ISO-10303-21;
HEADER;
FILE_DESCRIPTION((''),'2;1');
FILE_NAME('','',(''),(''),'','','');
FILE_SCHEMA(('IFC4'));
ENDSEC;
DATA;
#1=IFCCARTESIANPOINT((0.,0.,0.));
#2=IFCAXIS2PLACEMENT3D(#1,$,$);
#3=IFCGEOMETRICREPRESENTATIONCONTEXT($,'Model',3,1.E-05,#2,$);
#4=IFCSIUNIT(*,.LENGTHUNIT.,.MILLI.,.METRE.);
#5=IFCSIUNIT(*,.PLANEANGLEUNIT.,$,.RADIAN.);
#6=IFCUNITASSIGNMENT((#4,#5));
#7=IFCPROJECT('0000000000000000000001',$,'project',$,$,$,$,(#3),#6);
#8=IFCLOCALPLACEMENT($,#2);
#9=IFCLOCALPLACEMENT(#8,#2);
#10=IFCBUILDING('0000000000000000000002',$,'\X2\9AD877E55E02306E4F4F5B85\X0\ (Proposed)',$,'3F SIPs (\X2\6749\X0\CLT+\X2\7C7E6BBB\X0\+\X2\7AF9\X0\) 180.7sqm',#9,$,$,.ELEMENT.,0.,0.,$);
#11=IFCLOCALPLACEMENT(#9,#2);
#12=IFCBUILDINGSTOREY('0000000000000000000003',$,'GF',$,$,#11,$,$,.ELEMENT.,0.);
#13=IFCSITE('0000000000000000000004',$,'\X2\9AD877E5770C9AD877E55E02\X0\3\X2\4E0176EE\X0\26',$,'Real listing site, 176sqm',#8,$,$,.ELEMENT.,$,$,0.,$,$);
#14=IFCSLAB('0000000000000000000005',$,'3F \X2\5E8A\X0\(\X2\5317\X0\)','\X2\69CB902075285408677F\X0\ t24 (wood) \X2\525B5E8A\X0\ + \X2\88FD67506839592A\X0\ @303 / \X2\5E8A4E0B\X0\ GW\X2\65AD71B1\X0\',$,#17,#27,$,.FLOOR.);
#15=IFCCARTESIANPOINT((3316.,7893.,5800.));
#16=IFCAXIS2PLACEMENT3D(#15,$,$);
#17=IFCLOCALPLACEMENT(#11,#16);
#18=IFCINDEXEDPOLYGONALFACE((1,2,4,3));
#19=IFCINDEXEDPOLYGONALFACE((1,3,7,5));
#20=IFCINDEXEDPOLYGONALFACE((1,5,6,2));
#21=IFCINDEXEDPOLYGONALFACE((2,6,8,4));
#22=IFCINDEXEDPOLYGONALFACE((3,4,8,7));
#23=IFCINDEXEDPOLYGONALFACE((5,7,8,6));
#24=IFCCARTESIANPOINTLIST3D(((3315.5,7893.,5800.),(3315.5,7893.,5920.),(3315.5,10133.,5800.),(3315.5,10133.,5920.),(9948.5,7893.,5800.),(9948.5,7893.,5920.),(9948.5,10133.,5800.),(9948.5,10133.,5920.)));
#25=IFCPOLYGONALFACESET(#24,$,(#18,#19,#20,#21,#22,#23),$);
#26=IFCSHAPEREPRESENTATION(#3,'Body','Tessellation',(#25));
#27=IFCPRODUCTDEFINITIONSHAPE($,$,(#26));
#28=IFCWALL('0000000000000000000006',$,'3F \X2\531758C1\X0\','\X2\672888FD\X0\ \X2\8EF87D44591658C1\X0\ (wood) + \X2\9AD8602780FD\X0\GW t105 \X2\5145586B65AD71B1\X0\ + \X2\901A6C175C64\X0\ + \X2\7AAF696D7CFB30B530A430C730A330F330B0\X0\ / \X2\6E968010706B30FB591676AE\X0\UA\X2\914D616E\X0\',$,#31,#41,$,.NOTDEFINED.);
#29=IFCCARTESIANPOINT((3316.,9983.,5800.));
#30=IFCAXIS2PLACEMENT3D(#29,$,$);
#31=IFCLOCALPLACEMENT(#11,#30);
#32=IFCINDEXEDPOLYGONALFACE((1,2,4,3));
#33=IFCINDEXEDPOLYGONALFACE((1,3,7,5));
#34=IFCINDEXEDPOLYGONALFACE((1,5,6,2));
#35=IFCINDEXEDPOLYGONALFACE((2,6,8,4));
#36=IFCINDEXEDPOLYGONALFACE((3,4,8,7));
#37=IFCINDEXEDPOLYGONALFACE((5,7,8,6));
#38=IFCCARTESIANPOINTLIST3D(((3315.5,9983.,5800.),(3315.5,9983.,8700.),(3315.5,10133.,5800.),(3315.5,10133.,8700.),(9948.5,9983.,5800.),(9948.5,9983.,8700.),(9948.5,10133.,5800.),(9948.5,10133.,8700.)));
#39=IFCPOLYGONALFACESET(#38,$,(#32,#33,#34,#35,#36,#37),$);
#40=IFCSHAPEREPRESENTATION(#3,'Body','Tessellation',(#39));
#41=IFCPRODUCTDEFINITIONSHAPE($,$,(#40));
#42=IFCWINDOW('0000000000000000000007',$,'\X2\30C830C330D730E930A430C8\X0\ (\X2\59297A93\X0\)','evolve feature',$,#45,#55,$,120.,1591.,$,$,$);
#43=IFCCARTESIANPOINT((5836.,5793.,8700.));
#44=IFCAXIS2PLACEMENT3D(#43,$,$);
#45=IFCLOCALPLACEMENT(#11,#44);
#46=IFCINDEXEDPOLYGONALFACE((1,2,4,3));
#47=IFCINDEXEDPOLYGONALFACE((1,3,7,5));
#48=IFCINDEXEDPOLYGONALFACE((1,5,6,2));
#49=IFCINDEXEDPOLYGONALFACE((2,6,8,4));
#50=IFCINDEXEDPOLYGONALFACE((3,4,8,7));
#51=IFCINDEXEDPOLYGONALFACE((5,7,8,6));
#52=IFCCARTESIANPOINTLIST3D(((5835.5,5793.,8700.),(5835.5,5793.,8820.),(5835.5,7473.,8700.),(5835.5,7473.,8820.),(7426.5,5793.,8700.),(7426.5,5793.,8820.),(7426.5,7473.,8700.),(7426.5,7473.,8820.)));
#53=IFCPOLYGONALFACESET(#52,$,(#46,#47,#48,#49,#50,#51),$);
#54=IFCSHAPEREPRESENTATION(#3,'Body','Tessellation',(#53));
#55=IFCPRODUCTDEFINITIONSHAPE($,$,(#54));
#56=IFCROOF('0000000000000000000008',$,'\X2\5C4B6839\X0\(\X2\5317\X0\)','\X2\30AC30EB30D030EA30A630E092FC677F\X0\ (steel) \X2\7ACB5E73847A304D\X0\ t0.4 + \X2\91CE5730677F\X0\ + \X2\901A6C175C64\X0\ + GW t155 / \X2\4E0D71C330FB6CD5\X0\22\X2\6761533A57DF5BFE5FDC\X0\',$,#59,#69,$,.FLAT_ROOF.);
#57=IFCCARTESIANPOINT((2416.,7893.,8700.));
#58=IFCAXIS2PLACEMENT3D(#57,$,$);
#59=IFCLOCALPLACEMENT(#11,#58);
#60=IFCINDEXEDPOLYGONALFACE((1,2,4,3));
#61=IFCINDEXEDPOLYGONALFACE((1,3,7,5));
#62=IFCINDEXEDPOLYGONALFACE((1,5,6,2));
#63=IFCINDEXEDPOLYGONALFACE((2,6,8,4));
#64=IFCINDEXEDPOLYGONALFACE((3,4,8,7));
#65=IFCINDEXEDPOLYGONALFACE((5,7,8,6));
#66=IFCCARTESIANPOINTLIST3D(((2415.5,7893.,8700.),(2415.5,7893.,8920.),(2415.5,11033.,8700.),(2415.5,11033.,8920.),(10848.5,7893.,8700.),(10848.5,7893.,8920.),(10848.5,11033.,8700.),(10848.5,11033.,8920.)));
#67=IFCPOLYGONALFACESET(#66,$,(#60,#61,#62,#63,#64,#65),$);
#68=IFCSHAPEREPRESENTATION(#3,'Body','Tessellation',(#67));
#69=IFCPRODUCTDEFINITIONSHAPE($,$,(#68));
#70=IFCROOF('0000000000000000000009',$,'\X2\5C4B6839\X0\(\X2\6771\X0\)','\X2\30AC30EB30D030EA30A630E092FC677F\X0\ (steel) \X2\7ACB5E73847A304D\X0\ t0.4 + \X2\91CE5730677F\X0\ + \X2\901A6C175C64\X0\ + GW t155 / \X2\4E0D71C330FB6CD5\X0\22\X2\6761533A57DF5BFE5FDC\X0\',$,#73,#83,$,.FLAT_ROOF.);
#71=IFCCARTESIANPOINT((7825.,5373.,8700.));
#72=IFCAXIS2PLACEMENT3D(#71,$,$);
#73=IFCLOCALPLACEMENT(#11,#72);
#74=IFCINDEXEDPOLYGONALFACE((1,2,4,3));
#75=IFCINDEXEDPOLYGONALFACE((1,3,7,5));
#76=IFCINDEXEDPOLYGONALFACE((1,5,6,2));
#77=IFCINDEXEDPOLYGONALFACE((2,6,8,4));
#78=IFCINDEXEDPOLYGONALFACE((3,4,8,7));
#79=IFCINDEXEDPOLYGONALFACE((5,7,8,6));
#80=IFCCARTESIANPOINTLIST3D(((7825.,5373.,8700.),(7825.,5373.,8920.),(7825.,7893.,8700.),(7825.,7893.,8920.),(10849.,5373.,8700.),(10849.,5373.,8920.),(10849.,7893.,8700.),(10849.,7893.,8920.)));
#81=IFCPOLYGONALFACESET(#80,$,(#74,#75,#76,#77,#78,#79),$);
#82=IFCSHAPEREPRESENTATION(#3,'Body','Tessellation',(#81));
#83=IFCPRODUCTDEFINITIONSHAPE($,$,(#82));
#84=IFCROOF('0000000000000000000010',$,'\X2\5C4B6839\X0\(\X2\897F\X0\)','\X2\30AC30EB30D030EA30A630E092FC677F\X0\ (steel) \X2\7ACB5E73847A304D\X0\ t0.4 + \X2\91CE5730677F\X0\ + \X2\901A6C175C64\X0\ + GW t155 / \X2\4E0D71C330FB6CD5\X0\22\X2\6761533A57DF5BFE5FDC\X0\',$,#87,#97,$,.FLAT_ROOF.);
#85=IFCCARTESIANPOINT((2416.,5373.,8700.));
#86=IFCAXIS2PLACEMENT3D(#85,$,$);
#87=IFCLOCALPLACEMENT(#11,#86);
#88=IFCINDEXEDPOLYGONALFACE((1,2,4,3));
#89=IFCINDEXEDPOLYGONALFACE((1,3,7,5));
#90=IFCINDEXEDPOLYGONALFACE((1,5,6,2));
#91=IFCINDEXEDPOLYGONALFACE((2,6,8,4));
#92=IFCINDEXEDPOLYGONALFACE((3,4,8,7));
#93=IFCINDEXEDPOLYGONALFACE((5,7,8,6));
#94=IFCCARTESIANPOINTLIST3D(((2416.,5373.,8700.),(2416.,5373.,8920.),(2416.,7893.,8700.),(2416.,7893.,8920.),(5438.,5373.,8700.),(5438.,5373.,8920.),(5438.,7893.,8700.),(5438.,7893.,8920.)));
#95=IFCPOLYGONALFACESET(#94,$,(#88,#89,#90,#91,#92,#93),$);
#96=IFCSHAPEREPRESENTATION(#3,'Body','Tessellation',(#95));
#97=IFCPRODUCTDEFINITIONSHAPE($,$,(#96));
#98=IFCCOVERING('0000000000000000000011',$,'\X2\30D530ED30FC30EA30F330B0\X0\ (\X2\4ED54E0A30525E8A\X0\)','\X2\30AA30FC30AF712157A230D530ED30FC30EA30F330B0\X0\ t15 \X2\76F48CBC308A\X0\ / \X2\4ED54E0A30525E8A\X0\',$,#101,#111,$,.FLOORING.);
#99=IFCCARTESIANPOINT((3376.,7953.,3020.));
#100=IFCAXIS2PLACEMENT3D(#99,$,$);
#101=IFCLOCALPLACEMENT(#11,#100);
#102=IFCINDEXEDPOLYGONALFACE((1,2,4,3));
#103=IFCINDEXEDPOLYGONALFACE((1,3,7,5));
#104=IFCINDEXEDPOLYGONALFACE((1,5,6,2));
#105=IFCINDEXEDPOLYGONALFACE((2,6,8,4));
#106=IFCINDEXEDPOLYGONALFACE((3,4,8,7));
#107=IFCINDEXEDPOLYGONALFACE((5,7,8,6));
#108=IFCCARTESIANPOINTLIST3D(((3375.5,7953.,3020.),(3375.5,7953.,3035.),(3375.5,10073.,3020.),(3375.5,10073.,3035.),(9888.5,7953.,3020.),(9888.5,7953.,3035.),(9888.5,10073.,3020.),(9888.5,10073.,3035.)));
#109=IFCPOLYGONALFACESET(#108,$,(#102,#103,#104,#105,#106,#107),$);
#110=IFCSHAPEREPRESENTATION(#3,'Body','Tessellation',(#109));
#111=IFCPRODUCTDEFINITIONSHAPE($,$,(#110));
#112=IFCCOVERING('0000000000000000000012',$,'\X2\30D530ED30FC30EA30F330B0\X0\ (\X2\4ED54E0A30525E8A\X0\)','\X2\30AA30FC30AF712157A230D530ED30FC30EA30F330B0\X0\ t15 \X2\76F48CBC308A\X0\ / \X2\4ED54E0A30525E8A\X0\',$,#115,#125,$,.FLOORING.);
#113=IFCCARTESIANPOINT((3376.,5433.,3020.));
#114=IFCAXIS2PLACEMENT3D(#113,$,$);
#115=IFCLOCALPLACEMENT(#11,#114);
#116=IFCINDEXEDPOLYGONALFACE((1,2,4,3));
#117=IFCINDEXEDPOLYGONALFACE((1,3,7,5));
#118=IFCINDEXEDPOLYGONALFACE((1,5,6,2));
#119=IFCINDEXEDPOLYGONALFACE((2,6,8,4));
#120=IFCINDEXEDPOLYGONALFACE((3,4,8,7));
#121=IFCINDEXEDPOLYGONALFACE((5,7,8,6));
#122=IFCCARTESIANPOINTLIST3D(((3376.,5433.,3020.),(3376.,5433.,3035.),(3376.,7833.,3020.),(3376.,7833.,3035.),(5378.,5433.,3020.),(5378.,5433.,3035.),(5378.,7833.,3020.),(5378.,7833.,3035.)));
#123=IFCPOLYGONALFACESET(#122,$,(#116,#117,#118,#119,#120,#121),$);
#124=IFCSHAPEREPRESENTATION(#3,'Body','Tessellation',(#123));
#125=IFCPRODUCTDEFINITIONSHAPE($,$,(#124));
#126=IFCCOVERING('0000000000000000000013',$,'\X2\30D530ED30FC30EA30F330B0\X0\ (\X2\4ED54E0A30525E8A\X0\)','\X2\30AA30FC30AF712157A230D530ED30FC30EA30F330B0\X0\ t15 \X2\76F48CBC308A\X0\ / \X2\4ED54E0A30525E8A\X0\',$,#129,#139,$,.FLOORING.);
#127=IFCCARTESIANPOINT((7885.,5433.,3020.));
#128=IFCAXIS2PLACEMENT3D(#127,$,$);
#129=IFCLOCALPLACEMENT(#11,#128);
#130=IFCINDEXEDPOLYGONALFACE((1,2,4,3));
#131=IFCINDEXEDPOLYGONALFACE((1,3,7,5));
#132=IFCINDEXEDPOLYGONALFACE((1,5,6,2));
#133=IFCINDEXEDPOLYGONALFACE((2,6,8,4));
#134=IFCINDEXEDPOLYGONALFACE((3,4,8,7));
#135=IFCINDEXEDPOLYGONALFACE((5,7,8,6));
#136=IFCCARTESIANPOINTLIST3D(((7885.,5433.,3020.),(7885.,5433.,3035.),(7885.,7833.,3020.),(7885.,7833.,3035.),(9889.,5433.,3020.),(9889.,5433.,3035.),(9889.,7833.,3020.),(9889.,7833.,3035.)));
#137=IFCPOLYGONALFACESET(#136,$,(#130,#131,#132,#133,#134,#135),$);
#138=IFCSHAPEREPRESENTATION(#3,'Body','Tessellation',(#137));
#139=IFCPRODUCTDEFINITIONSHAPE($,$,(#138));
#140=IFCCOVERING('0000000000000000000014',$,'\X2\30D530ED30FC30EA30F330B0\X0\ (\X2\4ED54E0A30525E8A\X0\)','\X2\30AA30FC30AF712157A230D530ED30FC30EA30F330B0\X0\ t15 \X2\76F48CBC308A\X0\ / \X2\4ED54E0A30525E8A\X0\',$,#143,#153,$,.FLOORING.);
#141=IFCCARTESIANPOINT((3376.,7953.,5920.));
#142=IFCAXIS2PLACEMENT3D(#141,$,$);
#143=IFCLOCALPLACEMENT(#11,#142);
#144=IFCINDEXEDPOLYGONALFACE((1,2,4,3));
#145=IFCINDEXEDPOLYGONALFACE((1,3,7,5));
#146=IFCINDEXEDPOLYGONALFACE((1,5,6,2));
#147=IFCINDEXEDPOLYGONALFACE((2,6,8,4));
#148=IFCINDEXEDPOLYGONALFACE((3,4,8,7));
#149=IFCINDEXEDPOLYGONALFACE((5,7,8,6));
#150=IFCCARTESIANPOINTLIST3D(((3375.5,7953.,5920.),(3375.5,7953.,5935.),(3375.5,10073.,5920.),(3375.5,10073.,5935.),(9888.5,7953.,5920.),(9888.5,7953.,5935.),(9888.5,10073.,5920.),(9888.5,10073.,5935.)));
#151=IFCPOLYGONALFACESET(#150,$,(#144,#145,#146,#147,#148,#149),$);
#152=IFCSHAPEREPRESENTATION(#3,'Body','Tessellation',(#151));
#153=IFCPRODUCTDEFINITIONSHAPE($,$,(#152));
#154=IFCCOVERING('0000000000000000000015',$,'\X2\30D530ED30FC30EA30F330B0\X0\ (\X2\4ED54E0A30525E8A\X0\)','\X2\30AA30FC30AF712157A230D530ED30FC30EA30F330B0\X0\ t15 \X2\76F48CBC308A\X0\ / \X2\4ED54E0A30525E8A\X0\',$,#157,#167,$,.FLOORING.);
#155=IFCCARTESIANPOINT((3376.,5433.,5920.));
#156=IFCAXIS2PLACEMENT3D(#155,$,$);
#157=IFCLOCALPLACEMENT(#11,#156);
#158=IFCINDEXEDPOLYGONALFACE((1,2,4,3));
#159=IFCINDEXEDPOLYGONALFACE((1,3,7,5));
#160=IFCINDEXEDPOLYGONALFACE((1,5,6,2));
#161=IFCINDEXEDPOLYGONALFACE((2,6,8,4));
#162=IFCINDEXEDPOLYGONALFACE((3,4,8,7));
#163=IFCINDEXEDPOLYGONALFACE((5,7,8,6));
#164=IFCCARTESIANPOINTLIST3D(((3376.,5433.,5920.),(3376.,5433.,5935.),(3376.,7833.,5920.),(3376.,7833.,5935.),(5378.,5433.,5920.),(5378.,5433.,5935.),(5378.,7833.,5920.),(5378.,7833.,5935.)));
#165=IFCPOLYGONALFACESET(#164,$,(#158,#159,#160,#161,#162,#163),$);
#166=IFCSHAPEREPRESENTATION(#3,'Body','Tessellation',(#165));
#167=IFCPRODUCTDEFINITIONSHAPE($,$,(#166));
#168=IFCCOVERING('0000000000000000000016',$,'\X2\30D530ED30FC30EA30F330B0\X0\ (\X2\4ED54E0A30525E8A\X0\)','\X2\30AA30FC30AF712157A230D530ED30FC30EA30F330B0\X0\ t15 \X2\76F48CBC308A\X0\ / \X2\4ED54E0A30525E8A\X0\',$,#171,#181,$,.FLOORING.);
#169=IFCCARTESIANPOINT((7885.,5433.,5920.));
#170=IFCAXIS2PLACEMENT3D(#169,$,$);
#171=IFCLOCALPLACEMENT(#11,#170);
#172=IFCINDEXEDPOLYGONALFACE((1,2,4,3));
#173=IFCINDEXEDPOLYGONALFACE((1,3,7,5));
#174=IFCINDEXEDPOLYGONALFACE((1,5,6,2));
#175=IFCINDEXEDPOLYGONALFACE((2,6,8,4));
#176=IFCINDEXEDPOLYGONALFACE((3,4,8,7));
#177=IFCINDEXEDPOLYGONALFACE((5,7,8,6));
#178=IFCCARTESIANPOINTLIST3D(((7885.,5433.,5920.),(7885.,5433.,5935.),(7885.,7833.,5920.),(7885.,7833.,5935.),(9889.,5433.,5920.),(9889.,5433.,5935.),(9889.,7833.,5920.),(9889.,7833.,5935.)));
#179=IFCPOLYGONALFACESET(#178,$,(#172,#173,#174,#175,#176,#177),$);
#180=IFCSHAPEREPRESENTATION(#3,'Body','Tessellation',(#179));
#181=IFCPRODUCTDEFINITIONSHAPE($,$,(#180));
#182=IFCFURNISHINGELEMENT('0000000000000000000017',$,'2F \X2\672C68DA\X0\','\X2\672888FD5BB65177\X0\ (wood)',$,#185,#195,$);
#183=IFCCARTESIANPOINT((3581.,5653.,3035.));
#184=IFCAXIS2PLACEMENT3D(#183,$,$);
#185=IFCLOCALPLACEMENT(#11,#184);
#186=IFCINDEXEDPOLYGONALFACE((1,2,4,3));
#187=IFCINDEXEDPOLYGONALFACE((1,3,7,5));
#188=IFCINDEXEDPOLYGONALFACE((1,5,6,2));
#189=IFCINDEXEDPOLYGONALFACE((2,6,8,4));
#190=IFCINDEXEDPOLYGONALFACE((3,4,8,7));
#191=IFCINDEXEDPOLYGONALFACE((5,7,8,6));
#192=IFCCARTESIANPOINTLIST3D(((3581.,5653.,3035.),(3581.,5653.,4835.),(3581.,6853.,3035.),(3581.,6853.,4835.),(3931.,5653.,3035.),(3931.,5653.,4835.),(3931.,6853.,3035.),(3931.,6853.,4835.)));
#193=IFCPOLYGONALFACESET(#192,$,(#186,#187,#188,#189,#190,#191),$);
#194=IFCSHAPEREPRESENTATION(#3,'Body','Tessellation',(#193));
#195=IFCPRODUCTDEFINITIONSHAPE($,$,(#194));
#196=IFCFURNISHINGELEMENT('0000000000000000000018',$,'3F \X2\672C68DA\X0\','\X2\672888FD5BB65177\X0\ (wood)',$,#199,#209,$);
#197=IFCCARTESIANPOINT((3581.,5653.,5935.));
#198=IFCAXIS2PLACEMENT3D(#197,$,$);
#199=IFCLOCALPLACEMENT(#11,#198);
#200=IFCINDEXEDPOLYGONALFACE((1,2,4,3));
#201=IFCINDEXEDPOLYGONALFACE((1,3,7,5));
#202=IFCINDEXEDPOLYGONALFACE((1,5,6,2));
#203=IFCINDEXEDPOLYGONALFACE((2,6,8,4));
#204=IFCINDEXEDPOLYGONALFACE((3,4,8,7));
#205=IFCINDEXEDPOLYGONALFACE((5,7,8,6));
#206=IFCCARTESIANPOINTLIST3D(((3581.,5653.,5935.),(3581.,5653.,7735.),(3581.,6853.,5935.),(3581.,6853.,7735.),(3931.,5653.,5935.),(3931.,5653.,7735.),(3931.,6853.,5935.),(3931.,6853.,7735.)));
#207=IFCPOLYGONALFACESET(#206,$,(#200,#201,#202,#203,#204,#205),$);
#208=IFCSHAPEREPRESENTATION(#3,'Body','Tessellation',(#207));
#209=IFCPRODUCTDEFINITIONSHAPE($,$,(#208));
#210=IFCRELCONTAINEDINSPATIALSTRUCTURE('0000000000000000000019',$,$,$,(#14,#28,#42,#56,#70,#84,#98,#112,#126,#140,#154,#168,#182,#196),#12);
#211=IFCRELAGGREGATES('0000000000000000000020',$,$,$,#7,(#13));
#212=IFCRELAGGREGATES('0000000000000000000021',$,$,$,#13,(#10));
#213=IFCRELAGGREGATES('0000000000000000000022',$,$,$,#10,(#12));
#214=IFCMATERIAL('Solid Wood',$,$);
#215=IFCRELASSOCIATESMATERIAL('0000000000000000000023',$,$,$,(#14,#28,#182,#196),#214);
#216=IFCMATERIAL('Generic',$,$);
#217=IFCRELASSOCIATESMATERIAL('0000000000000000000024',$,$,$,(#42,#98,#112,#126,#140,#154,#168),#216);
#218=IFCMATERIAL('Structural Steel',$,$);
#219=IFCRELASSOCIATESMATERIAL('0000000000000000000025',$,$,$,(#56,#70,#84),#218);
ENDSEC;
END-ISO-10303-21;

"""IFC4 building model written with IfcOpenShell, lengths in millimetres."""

from ifc_helpers import new_model, si_unit, frame, frame_2d, origin, place, context, project, spatial, rectangle, extrude, material, element, save


model = new_model("IFC4")

# Units and contexts
model_context = context("Model", 3, precision=1e-05, world=origin())
ifc_project = project(units=[si_unit("LENGTHUNIT", "METRE", prefix="MILLI"), si_unit("PLANEANGLEUNIT", "RADIAN")], contexts=[model_context])

# Site, building, storey
site_placement = place(None, origin())
site = spatial("IfcSite", under=ifc_project, at=site_placement, Name="高知県高知市3丁目26", ObjectType="Real listing site, 176sqm", CompositionType="ELEMENT", RefElevation=0.0)
building_placement = place(site_placement, origin())
building = spatial("IfcBuilding", under=site, at=building_placement, Name="高知市の住宅 (Proposed)", ObjectType="3F SIPs (杉CLT+籾殻+竹) 180.7sqm", CompositionType="ELEMENT", ElevationOfRefHeight=0.0, ElevationOfTerrain=0.0)
storey_placement = place(building_placement, origin())
storey = spatial("IfcBuildingStorey", under=building, at=storey_placement, Name="GF", CompositionType="ELEMENT", Elevation=0.0)

# Slab
ifc_material_1 = material(Name="Solid Wood")
slab_placement = place(storey_placement, frame((3316.0, 7893.0, 5800.0)))
element("IfcSlab", 1, at=slab_placement, inside=storey, material=ifc_material_1, Name="3F 床(北)", Description="構造用合板 t24 (wood) 剛床 + 製材根太 @303 / 床下 GW断熱", PredefinedType="FLOOR", context=model_context, shape_type="SweptSolid", body=[
    extrude(rectangle(XDim=6633.0, YDim=2240.0, at=frame_2d((3316.0, 1120.0))), frame((3316.0, 7893.0, 5800.0)), (0.0, 0.0, 1.0), 120.0),
])

# Wall
wall_1_placement = place(storey_placement, frame((3316.0, 9983.0, 5800.0)))
element("IfcWall", 2, at=wall_1_placement, inside=storey, material=ifc_material_1, Name="3F 北壁", Description="木製 軸組外壁 (wood) + 高性能GW t105 充填断熱 + 通気層 + 窯業系サイディング / 準耐火・外皮UA配慮", PredefinedType="NOTDEFINED", context=model_context, shape_type="SweptSolid", body=[
    extrude(rectangle(XDim=6633.0, YDim=150.0, at=frame_2d((3316.0, 75.0))), frame((3316.0, 9983.0, 5800.0)), (0.0, 0.0, 1.0), 2900.0),
])

# Window
ifc_material_2 = material(Name="Generic")
window_1_placement = place(storey_placement, frame((5836.0, 5793.0, 8700.0)))
element("IfcWindow", 3, at=window_1_placement, inside=storey, material=ifc_material_2, Name="トップライト (天窓)", Description="evolve feature", OverallHeight=120.0, OverallWidth=1591.0, context=model_context, shape_type="SweptSolid", body=[
    extrude(rectangle(XDim=1591.0, YDim=1680.0, at=frame_2d((795.0, 840.0))), frame((5836.0, 5793.0, 8700.0)), (0.0, 0.0, 1.0), 120.0),
])

# Roofs
ifc_material_3 = material(Name="Structural Steel")
roof_1_placement = place(storey_placement, frame((2416.0, 7893.0, 8700.0)))
element("IfcRoof", 4, at=roof_1_placement, inside=storey, material=ifc_material_3, Name="屋根(北)", Description="ガルバリウム鋼板 (steel) 立平葺き t0.4 + 野地板 + 通気層 + GW t155 / 不燃・法22条区域対応", PredefinedType="FLAT_ROOF", context=model_context, shape_type="SweptSolid", body=[
    extrude(rectangle(XDim=8433.0, YDim=3140.0, at=frame_2d((4216.0, 1570.0))), frame((2416.0, 7893.0, 8700.0)), (0.0, 0.0, 1.0), 220.0),
])
roof_2_placement = place(storey_placement, frame((7825.0, 5373.0, 8700.0)))
element("IfcRoof", 5, at=roof_2_placement, inside=storey, material=ifc_material_3, Name="屋根(東)", Description="ガルバリウム鋼板 (steel) 立平葺き t0.4 + 野地板 + 通気層 + GW t155 / 不燃・法22条区域対応", PredefinedType="FLAT_ROOF", context=model_context, shape_type="SweptSolid", body=[
    extrude(rectangle(XDim=3024.0, YDim=2520.0, at=frame_2d((1512.0, 1260.0))), frame((7825.0, 5373.0, 8700.0)), (0.0, 0.0, 1.0), 220.0),
])
roof_3_placement = place(storey_placement, frame((2416.0, 5373.0, 8700.0)))
element("IfcRoof", 6, at=roof_3_placement, inside=storey, material=ifc_material_3, Name="屋根(西)", Description="ガルバリウム鋼板 (steel) 立平葺き t0.4 + 野地板 + 通気層 + GW t155 / 不燃・法22条区域対応", PredefinedType="FLAT_ROOF", context=model_context, shape_type="SweptSolid", body=[
    extrude(rectangle(XDim=3022.0, YDim=2520.0, at=frame_2d((1511.0, 1260.0))), frame((2416.0, 5373.0, 8700.0)), (0.0, 0.0, 1.0), 220.0),
])

# Coverings
covering_1_placement = place(storey_placement, frame((3376.0, 7953.0, 3020.0)))
element("IfcCovering", 7, at=covering_1_placement, inside=storey, material=ifc_material_2, Name="フローリング (仕上げ床)", Description="オーク無垢フローリング t15 直貼り / 仕上げ床", PredefinedType="FLOORING", context=model_context, shape_type="SweptSolid", body=[
    extrude(rectangle(XDim=6513.0, YDim=2120.0, at=frame_2d((3256.0, 1060.0))), frame((3376.0, 7953.0, 3020.0)), (0.0, 0.0, 1.0), 15.0),
])
covering_2_placement = place(storey_placement, frame((3376.0, 5433.0, 3020.0)))
element("IfcCovering", 8, at=covering_2_placement, inside=storey, material=ifc_material_2, Name="フローリング (仕上げ床)", Description="オーク無垢フローリング t15 直貼り / 仕上げ床", PredefinedType="FLOORING", context=model_context, shape_type="SweptSolid", body=[
    extrude(rectangle(XDim=2002.0, YDim=2400.0, at=frame_2d((1001.0, 1200.0))), frame((3376.0, 5433.0, 3020.0)), (0.0, 0.0, 1.0), 15.0),
])
covering_3_placement = place(storey_placement, frame((7885.0, 5433.0, 3020.0)))
element("IfcCovering", 9, at=covering_3_placement, inside=storey, material=ifc_material_2, Name="フローリング (仕上げ床)", Description="オーク無垢フローリング t15 直貼り / 仕上げ床", PredefinedType="FLOORING", context=model_context, shape_type="SweptSolid", body=[
    extrude(rectangle(XDim=2004.0, YDim=2400.0, at=frame_2d((1002.0, 1200.0))), frame((7885.0, 5433.0, 3020.0)), (0.0, 0.0, 1.0), 15.0),
])
covering_4_placement = place(storey_placement, frame((3376.0, 7953.0, 5920.0)))
element("IfcCovering", 10, at=covering_4_placement, inside=storey, material=ifc_material_2, Name="フローリング (仕上げ床)", Description="オーク無垢フローリング t15 直貼り / 仕上げ床", PredefinedType="FLOORING", context=model_context, shape_type="SweptSolid", body=[
    extrude(rectangle(XDim=6513.0, YDim=2120.0, at=frame_2d((3256.0, 1060.0))), frame((3376.0, 7953.0, 5920.0)), (0.0, 0.0, 1.0), 15.0),
])
covering_5_placement = place(storey_placement, frame((3376.0, 5433.0, 5920.0)))
element("IfcCovering", 11, at=covering_5_placement, inside=storey, material=ifc_material_2, Name="フローリング (仕上げ床)", Description="オーク無垢フローリング t15 直貼り / 仕上げ床", PredefinedType="FLOORING", context=model_context, shape_type="SweptSolid", body=[
    extrude(rectangle(XDim=2002.0, YDim=2400.0, at=frame_2d((1001.0, 1200.0))), frame((3376.0, 5433.0, 5920.0)), (0.0, 0.0, 1.0), 15.0),
])
covering_6_placement = place(storey_placement, frame((7885.0, 5433.0, 5920.0)))
element("IfcCovering", 12, at=covering_6_placement, inside=storey, material=ifc_material_2, Name="フローリング (仕上げ床)", Description="オーク無垢フローリング t15 直貼り / 仕上げ床", PredefinedType="FLOORING", context=model_context, shape_type="SweptSolid", body=[
    extrude(rectangle(XDim=2004.0, YDim=2400.0, at=frame_2d((1002.0, 1200.0))), frame((7885.0, 5433.0, 5920.0)), (0.0, 0.0, 1.0), 15.0),
])

# Furnishing elements
furnishing_1_placement = place(storey_placement, frame((3581.0, 5653.0, 3035.0)))
element("IfcFurnishingElement", 13, at=furnishing_1_placement, inside=storey, material=ifc_material_1, Name="2F 本棚", Description="木製家具 (wood)", context=model_context, shape_type="SweptSolid", body=[
    extrude(rectangle(XDim=350.0, YDim=1200.0, at=frame_2d((175.0, 600.0))), frame((3581.0, 5653.0, 3035.0)), (0.0, 0.0, 1.0), 1800.0),
])
furnishing_2_placement = place(storey_placement, frame((3581.0, 5653.0, 5935.0)))
element("IfcFurnishingElement", 14, at=furnishing_2_placement, inside=storey, material=ifc_material_1, Name="3F 本棚", Description="木製家具 (wood)", context=model_context, shape_type="SweptSolid", body=[
    extrude(rectangle(XDim=350.0, YDim=1200.0, at=frame_2d((175.0, 600.0))), frame((3581.0, 5653.0, 5935.0)), (0.0, 0.0, 1.0), 1800.0),
])

save(model, "model.ifc")
